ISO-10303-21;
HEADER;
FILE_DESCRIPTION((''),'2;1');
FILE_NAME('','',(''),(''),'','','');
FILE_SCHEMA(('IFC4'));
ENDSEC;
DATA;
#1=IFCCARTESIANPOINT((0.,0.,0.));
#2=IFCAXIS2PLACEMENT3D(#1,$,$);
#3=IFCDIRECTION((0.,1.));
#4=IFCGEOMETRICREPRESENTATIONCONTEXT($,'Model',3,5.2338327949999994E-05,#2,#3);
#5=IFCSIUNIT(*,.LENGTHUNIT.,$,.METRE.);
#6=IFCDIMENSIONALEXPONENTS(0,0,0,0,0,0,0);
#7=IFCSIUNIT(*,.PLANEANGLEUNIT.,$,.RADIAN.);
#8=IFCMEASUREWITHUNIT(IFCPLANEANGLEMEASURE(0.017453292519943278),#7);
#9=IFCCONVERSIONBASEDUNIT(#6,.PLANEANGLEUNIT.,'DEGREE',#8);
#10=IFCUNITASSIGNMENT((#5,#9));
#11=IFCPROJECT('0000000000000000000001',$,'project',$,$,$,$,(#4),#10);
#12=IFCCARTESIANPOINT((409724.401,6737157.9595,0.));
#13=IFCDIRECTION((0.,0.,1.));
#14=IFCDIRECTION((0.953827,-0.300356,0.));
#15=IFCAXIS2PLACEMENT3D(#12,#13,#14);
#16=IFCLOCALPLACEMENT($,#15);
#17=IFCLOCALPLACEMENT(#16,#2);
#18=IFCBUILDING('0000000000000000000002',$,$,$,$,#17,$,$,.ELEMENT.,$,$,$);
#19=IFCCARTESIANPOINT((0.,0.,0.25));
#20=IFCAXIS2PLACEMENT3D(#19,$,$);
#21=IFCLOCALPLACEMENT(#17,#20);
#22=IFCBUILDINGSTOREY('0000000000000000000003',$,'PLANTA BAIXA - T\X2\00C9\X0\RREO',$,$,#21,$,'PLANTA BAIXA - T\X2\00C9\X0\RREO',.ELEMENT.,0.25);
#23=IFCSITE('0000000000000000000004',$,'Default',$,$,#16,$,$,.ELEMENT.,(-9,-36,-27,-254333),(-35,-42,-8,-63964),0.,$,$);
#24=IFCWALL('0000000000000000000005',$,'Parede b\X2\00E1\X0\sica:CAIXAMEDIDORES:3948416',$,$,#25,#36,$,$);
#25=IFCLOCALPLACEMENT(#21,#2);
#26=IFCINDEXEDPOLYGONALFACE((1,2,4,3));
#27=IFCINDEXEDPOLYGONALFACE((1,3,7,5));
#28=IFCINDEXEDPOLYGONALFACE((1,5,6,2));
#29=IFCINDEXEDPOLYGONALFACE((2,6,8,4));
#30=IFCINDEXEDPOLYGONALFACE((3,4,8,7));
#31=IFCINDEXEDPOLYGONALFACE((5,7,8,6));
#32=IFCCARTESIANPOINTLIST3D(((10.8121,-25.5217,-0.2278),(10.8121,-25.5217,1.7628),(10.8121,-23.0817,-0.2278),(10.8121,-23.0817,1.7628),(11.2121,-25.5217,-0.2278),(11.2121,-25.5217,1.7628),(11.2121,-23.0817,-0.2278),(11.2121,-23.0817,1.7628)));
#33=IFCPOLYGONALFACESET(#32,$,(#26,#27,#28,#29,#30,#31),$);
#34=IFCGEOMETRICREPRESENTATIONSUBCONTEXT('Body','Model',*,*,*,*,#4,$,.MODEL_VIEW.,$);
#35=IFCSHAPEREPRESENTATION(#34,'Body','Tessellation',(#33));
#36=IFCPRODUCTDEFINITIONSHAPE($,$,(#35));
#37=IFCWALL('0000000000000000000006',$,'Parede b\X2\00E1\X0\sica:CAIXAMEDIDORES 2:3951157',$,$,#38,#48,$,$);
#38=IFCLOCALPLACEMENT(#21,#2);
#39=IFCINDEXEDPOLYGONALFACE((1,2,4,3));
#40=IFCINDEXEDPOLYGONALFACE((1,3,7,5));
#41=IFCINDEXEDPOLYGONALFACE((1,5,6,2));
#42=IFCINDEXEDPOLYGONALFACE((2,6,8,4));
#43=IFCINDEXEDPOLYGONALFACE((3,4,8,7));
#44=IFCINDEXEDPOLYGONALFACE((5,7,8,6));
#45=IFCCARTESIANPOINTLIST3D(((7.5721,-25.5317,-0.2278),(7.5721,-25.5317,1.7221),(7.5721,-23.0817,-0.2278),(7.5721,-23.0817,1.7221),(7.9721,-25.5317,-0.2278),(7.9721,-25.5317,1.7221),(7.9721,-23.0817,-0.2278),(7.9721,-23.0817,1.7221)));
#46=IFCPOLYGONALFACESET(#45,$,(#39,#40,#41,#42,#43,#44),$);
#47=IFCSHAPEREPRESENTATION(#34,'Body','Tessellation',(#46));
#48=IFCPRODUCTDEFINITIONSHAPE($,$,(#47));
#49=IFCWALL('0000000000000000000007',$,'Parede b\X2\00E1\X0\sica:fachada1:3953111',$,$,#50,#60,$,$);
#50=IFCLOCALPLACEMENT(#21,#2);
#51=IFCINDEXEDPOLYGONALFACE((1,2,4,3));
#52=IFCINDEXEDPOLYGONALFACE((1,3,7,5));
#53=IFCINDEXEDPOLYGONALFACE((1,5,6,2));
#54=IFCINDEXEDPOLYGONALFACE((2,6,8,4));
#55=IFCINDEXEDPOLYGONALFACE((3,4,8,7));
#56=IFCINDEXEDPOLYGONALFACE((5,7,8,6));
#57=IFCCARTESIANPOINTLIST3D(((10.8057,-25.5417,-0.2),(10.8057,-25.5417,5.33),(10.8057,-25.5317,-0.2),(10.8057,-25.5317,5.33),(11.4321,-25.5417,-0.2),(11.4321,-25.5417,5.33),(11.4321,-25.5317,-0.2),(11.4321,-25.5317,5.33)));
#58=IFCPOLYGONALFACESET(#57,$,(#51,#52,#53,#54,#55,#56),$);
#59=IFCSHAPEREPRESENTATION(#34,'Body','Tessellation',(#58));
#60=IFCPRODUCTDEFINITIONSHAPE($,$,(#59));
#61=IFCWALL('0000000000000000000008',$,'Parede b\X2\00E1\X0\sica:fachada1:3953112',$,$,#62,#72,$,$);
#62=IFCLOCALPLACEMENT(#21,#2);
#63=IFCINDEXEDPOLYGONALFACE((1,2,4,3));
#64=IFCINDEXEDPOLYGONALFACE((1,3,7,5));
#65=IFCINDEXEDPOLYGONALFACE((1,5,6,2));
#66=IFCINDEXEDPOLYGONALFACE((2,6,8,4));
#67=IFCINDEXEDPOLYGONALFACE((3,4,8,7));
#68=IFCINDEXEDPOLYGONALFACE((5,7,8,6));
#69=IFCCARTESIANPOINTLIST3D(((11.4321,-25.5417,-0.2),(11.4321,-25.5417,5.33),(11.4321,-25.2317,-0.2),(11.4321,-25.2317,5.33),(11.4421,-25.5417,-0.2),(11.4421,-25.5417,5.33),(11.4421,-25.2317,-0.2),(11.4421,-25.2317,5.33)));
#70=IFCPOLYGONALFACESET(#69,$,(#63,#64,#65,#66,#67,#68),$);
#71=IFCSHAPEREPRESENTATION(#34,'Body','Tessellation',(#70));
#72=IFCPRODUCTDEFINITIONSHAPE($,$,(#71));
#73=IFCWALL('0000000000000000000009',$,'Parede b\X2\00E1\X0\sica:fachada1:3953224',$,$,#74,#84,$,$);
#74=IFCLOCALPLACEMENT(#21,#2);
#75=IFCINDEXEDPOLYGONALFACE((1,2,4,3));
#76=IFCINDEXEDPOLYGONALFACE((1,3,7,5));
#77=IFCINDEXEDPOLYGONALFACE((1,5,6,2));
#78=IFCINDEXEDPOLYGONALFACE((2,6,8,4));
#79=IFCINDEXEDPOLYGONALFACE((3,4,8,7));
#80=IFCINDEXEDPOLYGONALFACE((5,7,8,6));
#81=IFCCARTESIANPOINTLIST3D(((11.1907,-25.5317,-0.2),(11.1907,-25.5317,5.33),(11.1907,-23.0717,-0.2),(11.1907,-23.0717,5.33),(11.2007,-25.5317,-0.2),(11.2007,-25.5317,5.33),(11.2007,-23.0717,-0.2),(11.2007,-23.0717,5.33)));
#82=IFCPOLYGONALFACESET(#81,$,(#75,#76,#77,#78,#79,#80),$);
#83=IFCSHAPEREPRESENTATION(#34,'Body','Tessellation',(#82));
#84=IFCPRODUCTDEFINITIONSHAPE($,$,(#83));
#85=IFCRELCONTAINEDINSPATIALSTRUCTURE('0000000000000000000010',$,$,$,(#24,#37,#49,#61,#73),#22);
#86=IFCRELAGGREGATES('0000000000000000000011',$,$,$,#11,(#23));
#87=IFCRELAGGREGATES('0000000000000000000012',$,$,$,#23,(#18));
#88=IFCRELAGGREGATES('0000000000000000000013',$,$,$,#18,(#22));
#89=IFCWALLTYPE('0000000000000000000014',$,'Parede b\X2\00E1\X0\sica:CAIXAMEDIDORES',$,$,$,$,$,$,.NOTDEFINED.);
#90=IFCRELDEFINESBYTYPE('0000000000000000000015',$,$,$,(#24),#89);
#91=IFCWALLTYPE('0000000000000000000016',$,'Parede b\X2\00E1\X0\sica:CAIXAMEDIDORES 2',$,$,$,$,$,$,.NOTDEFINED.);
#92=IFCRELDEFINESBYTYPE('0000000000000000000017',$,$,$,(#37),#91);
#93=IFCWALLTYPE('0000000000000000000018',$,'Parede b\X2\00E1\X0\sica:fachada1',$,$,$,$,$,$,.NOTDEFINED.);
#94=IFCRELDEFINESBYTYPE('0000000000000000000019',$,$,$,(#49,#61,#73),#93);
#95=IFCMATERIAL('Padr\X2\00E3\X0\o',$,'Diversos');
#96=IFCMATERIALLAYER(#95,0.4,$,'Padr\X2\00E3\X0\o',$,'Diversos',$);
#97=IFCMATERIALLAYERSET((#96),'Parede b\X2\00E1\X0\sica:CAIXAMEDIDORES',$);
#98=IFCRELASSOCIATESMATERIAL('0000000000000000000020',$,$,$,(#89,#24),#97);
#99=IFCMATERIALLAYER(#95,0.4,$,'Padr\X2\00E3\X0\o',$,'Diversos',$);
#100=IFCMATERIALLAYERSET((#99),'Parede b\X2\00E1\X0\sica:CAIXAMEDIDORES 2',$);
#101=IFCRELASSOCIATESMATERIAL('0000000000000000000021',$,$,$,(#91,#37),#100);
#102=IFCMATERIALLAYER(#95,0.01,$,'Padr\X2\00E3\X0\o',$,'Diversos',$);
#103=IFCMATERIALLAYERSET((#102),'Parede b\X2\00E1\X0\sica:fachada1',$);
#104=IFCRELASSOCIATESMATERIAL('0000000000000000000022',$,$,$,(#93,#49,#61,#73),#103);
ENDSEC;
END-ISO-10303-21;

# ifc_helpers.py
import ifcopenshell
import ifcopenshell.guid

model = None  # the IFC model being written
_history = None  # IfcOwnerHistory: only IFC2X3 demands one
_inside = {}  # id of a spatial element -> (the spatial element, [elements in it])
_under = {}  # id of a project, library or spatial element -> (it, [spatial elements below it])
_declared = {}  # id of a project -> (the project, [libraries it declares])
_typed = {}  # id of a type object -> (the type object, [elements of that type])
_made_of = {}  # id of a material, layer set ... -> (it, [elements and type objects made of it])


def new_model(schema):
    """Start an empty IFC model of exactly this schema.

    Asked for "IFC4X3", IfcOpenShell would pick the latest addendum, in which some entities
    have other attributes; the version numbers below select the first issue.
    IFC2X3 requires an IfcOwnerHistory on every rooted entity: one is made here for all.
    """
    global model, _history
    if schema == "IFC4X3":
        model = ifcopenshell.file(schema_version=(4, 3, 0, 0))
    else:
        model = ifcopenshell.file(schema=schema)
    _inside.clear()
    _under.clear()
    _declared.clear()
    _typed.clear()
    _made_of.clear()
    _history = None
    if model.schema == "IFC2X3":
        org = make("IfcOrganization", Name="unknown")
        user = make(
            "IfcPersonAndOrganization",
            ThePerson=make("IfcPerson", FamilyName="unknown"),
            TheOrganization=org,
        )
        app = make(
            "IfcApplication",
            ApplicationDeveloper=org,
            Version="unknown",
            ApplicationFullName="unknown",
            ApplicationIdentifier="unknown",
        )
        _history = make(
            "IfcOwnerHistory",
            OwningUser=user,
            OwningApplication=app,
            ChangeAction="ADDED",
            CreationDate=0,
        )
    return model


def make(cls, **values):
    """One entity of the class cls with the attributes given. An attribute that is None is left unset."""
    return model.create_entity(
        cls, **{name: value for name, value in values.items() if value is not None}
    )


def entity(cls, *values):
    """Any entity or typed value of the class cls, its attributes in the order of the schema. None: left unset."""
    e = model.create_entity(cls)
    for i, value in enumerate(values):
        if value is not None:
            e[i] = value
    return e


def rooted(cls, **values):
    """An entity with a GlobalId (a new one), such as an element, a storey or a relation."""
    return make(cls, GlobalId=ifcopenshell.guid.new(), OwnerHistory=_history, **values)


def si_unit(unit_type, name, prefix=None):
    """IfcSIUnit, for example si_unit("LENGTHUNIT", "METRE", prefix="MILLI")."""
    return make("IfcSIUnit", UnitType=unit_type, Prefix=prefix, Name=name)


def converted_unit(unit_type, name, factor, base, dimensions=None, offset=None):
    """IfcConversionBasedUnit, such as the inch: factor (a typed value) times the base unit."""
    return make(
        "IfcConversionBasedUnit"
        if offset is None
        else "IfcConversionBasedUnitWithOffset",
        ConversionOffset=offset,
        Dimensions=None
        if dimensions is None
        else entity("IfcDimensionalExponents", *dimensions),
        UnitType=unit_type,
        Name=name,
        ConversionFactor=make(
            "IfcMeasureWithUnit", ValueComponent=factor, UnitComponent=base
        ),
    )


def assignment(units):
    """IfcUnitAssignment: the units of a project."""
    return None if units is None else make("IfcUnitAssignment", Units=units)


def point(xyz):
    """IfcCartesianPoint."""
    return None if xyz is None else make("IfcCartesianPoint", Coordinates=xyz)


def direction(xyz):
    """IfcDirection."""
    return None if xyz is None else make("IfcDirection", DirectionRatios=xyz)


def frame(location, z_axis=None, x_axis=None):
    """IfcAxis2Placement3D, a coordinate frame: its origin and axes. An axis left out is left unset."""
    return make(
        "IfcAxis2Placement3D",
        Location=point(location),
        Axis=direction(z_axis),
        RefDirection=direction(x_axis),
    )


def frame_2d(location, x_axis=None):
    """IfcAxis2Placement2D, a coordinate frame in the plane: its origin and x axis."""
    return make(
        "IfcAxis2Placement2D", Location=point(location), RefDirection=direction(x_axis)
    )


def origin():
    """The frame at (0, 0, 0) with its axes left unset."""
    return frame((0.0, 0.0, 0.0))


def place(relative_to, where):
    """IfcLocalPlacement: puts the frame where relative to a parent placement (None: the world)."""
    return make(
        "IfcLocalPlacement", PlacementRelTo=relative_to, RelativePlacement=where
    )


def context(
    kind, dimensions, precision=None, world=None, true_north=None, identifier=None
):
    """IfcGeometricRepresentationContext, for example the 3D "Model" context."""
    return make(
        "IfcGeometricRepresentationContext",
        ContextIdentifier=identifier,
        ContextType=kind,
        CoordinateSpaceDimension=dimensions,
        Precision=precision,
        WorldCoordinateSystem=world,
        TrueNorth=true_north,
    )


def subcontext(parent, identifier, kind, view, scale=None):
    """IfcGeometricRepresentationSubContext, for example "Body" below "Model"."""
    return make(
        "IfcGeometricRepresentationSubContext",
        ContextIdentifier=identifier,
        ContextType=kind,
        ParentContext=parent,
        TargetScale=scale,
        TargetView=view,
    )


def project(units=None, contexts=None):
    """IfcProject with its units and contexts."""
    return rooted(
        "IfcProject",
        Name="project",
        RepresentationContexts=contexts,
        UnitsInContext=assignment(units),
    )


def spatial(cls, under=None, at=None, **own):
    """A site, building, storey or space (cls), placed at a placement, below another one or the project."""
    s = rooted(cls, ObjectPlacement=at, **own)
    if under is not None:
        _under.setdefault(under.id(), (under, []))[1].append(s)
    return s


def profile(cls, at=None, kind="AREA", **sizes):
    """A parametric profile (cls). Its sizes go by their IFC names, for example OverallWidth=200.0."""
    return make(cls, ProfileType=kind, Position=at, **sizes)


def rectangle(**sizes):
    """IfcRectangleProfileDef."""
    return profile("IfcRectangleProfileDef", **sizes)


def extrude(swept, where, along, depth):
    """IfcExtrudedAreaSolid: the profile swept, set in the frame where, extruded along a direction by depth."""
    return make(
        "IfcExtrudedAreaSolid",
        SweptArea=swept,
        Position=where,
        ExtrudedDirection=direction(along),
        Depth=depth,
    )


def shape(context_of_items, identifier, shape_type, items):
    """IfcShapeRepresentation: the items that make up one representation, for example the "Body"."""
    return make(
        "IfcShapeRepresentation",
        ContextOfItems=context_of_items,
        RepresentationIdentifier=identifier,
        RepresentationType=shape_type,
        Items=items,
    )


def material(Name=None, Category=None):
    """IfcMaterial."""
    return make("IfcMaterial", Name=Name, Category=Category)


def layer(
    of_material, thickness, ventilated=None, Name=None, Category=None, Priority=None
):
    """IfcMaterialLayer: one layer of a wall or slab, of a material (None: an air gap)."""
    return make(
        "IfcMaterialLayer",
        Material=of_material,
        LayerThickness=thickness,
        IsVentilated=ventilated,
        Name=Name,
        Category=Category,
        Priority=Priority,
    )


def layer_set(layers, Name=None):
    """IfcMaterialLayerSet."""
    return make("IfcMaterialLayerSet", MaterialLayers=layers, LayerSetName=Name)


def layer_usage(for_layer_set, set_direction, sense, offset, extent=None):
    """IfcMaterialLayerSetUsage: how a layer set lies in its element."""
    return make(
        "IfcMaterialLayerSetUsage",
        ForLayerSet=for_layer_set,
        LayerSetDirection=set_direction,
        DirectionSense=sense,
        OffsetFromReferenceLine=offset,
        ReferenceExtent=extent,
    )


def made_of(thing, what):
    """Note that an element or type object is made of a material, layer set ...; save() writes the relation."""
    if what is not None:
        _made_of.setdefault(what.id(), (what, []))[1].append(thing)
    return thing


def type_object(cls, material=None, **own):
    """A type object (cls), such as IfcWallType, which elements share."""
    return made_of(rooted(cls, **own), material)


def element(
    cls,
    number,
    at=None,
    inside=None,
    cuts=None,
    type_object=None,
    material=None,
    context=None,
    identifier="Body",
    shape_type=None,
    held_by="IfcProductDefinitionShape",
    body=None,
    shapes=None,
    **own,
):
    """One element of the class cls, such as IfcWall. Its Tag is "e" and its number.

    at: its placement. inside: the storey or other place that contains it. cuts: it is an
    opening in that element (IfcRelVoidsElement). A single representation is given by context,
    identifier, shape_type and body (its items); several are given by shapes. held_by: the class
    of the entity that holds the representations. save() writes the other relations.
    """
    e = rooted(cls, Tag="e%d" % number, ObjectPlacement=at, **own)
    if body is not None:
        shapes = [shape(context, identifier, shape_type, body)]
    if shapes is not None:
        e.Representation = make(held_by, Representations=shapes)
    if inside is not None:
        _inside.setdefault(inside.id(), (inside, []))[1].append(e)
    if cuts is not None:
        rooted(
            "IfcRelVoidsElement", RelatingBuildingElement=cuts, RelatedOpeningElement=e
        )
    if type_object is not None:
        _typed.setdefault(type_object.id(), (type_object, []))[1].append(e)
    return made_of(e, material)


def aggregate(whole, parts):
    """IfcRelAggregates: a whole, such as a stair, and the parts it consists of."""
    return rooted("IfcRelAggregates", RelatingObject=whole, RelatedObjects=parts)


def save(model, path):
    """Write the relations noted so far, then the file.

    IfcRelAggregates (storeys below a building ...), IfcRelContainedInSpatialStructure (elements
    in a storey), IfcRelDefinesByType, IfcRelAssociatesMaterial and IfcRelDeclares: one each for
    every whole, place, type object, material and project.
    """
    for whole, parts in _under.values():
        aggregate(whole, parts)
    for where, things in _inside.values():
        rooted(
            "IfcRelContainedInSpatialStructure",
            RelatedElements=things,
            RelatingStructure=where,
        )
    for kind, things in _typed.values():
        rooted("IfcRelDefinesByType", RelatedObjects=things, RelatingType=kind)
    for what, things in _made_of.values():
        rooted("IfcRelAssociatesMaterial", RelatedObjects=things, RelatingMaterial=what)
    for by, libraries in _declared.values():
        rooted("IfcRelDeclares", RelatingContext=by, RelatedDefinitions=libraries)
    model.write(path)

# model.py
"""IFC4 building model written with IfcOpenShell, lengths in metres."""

from ifc_helpers import new_model, entity, si_unit, converted_unit, direction, frame, frame_2d, origin, place, context, subcontext, project, spatial, rectangle, extrude, material, layer, layer_set, layer_usage, type_object, element, save


model = new_model("IFC4")

# Units and contexts
model_context = context("Model", 3, precision=5.2338327949999994e-05, world=origin(), true_north=direction((0.0, 1.0)))
body_context = subcontext(model_context, "Body", "Model", "MODEL_VIEW")
ifc_project = project(units=[si_unit("LENGTHUNIT", "METRE"), converted_unit("PLANEANGLEUNIT", "DEGREE", entity("IfcPlaneAngleMeasure", 0.017453292519943278), si_unit("PLANEANGLEUNIT", "RADIAN"), dimensions=[0, 0, 0, 0, 0, 0, 0])], contexts=[model_context])

# Site, building, storey
site_placement = place(None, frame((409724.401, 6737157.9595, 0.0), z_axis=(0.0, 0.0, 1.0), x_axis=(0.953827, -0.300356, 0.0)))
site = spatial("IfcSite", under=ifc_project, at=site_placement, Name="Default", CompositionType="ELEMENT", RefLatitude=(-9, -36, -27, -254333), RefLongitude=(-35, -42, -8, -63964), RefElevation=0.0)
building_placement = place(site_placement, origin())
building = spatial("IfcBuilding", under=site, at=building_placement, CompositionType="ELEMENT")
storey_placement = place(building_placement, frame((0.0, 0.0, 0.25)))
storey = spatial("IfcBuildingStorey", under=building, at=storey_placement, Name="PLANTA BAIXA - TÉRREO", LongName="PLANTA BAIXA - TÉRREO", CompositionType="ELEMENT", Elevation=0.25)

# Walls
ifc_material_1 = material(Name="Padrão", Category="Diversos")
ifc_layer_1 = layer(ifc_material_1, 0.4, Name="Padrão", Category="Diversos")
ifc_layer_set_1 = layer_set([ifc_layer_1], Name="Parede básica:CAIXAMEDIDORES")
ifc_layer_usage_1 = layer_usage(ifc_layer_set_1, "AXIS2", "NEGATIVE", 0.2)
wall_type_1 = type_object("IfcWallType", Name="Parede básica:CAIXAMEDIDORES", PredefinedType="NOTDEFINED", material=ifc_layer_set_1)
wall_1_placement = place(storey_placement, frame((11.0121, -23.0817, -0.2278), z_axis=(0.0, 0.0, 1.0), x_axis=(0.0, -1.0, 0.0)))
element("IfcWall", 1, at=wall_1_placement, inside=storey, type_object=wall_type_1, material=ifc_layer_usage_1, Name="Parede básica:CAIXAMEDIDORES:3948416", context=body_context, shape_type="SweptSolid", body=[
    extrude(rectangle(XDim=2.44, YDim=0.4, at=frame_2d((1.22, 0.0), x_axis=(-1.0, 0.0))), origin(), (0.0, 0.0, 1.0), 1.9905),
])
ifc_layer_2 = layer(ifc_material_1, 0.4, Name="Padrão", Category="Diversos")
ifc_layer_set_2 = layer_set([ifc_layer_2], Name="Parede básica:CAIXAMEDIDORES 2")
ifc_layer_usage_2 = layer_usage(ifc_layer_set_2, "AXIS2", "NEGATIVE", 0.2)
wall_type_2 = type_object("IfcWallType", Name="Parede básica:CAIXAMEDIDORES 2", PredefinedType="NOTDEFINED", material=ifc_layer_set_2)
wall_2_placement = place(storey_placement, frame((7.7721, -23.0817, -0.2278), z_axis=(0.0, 0.0, 1.0), x_axis=(0.0, -1.0, 0.0)))
element("IfcWall", 2, at=wall_2_placement, inside=storey, type_object=wall_type_2, material=ifc_layer_usage_2, Name="Parede básica:CAIXAMEDIDORES 2:3951157", context=body_context, shape_type="SweptSolid", body=[
    extrude(rectangle(XDim=2.45, YDim=0.4, at=frame_2d((1.225, 0.0), x_axis=(-1.0, 0.0))), origin(), (0.0, 0.0, 1.0), 1.9499),
])
ifc_layer_3 = layer(ifc_material_1, 0.01, Name="Padrão", Category="Diversos")
ifc_layer_set_3 = layer_set([ifc_layer_3], Name="Parede básica:fachada1")
ifc_layer_usage_3 = layer_usage(ifc_layer_set_3, "AXIS2", "POSITIVE", -0.005)
wall_type_3 = type_object("IfcWallType", Name="Parede básica:fachada1", PredefinedType="NOTDEFINED", material=ifc_layer_set_3)
wall_3_placement = place(storey_placement, frame((11.4321, -25.5367, -0.2), z_axis=(0.0, 0.0, 1.0), x_axis=(-1.0, 0.0, 0.0)))
element("IfcWall", 3, at=wall_3_placement, inside=storey, type_object=wall_type_3, material=ifc_layer_usage_3, Name="Parede básica:fachada1:3953111", context=body_context, shape_type="SweptSolid", body=[
    extrude(rectangle(XDim=0.6264, YDim=0.01, at=frame_2d((0.3132, 0.0), x_axis=(-1.0, 0.0))), origin(), (0.0, 0.0, 1.0), 5.53),
])
ifc_layer_usage_4 = layer_usage(ifc_layer_set_3, "AXIS2", "POSITIVE", -0.005)
wall_4_placement = place(storey_placement, frame((11.4371, -25.2317, -0.2), z_axis=(0.0, 0.0, 1.0), x_axis=(0.0, -1.0, 0.0)))
element("IfcWall", 4, at=wall_4_placement, inside=storey, type_object=wall_type_3, material=ifc_layer_usage_4, Name="Parede básica:fachada1:3953112", context=body_context, shape_type="SweptSolid", body=[
    extrude(rectangle(XDim=0.31, YDim=0.01, at=frame_2d((0.155, 0.0), x_axis=(-1.0, 0.0))), origin(), (0.0, 0.0, 1.0), 5.53),
])
ifc_layer_usage_5 = layer_usage(ifc_layer_set_3, "AXIS2", "POSITIVE", -0.005)
wall_5_placement = place(storey_placement, frame((11.1957, -25.5317, -0.2), z_axis=(0.0, 0.0, 1.0), x_axis=(0.0, 1.0, 0.0)))
element("IfcWall", 5, at=wall_5_placement, inside=storey, type_object=wall_type_3, material=ifc_layer_usage_5, Name="Parede básica:fachada1:3953224", context=body_context, shape_type="SweptSolid", body=[
    extrude(rectangle(XDim=2.46, YDim=0.01, at=frame_2d((1.23, 0.0), x_axis=(-1.0, 0.0))), origin(), (0.0, 0.0, 1.0), 5.53),
])

save(model, "model.ifc")
